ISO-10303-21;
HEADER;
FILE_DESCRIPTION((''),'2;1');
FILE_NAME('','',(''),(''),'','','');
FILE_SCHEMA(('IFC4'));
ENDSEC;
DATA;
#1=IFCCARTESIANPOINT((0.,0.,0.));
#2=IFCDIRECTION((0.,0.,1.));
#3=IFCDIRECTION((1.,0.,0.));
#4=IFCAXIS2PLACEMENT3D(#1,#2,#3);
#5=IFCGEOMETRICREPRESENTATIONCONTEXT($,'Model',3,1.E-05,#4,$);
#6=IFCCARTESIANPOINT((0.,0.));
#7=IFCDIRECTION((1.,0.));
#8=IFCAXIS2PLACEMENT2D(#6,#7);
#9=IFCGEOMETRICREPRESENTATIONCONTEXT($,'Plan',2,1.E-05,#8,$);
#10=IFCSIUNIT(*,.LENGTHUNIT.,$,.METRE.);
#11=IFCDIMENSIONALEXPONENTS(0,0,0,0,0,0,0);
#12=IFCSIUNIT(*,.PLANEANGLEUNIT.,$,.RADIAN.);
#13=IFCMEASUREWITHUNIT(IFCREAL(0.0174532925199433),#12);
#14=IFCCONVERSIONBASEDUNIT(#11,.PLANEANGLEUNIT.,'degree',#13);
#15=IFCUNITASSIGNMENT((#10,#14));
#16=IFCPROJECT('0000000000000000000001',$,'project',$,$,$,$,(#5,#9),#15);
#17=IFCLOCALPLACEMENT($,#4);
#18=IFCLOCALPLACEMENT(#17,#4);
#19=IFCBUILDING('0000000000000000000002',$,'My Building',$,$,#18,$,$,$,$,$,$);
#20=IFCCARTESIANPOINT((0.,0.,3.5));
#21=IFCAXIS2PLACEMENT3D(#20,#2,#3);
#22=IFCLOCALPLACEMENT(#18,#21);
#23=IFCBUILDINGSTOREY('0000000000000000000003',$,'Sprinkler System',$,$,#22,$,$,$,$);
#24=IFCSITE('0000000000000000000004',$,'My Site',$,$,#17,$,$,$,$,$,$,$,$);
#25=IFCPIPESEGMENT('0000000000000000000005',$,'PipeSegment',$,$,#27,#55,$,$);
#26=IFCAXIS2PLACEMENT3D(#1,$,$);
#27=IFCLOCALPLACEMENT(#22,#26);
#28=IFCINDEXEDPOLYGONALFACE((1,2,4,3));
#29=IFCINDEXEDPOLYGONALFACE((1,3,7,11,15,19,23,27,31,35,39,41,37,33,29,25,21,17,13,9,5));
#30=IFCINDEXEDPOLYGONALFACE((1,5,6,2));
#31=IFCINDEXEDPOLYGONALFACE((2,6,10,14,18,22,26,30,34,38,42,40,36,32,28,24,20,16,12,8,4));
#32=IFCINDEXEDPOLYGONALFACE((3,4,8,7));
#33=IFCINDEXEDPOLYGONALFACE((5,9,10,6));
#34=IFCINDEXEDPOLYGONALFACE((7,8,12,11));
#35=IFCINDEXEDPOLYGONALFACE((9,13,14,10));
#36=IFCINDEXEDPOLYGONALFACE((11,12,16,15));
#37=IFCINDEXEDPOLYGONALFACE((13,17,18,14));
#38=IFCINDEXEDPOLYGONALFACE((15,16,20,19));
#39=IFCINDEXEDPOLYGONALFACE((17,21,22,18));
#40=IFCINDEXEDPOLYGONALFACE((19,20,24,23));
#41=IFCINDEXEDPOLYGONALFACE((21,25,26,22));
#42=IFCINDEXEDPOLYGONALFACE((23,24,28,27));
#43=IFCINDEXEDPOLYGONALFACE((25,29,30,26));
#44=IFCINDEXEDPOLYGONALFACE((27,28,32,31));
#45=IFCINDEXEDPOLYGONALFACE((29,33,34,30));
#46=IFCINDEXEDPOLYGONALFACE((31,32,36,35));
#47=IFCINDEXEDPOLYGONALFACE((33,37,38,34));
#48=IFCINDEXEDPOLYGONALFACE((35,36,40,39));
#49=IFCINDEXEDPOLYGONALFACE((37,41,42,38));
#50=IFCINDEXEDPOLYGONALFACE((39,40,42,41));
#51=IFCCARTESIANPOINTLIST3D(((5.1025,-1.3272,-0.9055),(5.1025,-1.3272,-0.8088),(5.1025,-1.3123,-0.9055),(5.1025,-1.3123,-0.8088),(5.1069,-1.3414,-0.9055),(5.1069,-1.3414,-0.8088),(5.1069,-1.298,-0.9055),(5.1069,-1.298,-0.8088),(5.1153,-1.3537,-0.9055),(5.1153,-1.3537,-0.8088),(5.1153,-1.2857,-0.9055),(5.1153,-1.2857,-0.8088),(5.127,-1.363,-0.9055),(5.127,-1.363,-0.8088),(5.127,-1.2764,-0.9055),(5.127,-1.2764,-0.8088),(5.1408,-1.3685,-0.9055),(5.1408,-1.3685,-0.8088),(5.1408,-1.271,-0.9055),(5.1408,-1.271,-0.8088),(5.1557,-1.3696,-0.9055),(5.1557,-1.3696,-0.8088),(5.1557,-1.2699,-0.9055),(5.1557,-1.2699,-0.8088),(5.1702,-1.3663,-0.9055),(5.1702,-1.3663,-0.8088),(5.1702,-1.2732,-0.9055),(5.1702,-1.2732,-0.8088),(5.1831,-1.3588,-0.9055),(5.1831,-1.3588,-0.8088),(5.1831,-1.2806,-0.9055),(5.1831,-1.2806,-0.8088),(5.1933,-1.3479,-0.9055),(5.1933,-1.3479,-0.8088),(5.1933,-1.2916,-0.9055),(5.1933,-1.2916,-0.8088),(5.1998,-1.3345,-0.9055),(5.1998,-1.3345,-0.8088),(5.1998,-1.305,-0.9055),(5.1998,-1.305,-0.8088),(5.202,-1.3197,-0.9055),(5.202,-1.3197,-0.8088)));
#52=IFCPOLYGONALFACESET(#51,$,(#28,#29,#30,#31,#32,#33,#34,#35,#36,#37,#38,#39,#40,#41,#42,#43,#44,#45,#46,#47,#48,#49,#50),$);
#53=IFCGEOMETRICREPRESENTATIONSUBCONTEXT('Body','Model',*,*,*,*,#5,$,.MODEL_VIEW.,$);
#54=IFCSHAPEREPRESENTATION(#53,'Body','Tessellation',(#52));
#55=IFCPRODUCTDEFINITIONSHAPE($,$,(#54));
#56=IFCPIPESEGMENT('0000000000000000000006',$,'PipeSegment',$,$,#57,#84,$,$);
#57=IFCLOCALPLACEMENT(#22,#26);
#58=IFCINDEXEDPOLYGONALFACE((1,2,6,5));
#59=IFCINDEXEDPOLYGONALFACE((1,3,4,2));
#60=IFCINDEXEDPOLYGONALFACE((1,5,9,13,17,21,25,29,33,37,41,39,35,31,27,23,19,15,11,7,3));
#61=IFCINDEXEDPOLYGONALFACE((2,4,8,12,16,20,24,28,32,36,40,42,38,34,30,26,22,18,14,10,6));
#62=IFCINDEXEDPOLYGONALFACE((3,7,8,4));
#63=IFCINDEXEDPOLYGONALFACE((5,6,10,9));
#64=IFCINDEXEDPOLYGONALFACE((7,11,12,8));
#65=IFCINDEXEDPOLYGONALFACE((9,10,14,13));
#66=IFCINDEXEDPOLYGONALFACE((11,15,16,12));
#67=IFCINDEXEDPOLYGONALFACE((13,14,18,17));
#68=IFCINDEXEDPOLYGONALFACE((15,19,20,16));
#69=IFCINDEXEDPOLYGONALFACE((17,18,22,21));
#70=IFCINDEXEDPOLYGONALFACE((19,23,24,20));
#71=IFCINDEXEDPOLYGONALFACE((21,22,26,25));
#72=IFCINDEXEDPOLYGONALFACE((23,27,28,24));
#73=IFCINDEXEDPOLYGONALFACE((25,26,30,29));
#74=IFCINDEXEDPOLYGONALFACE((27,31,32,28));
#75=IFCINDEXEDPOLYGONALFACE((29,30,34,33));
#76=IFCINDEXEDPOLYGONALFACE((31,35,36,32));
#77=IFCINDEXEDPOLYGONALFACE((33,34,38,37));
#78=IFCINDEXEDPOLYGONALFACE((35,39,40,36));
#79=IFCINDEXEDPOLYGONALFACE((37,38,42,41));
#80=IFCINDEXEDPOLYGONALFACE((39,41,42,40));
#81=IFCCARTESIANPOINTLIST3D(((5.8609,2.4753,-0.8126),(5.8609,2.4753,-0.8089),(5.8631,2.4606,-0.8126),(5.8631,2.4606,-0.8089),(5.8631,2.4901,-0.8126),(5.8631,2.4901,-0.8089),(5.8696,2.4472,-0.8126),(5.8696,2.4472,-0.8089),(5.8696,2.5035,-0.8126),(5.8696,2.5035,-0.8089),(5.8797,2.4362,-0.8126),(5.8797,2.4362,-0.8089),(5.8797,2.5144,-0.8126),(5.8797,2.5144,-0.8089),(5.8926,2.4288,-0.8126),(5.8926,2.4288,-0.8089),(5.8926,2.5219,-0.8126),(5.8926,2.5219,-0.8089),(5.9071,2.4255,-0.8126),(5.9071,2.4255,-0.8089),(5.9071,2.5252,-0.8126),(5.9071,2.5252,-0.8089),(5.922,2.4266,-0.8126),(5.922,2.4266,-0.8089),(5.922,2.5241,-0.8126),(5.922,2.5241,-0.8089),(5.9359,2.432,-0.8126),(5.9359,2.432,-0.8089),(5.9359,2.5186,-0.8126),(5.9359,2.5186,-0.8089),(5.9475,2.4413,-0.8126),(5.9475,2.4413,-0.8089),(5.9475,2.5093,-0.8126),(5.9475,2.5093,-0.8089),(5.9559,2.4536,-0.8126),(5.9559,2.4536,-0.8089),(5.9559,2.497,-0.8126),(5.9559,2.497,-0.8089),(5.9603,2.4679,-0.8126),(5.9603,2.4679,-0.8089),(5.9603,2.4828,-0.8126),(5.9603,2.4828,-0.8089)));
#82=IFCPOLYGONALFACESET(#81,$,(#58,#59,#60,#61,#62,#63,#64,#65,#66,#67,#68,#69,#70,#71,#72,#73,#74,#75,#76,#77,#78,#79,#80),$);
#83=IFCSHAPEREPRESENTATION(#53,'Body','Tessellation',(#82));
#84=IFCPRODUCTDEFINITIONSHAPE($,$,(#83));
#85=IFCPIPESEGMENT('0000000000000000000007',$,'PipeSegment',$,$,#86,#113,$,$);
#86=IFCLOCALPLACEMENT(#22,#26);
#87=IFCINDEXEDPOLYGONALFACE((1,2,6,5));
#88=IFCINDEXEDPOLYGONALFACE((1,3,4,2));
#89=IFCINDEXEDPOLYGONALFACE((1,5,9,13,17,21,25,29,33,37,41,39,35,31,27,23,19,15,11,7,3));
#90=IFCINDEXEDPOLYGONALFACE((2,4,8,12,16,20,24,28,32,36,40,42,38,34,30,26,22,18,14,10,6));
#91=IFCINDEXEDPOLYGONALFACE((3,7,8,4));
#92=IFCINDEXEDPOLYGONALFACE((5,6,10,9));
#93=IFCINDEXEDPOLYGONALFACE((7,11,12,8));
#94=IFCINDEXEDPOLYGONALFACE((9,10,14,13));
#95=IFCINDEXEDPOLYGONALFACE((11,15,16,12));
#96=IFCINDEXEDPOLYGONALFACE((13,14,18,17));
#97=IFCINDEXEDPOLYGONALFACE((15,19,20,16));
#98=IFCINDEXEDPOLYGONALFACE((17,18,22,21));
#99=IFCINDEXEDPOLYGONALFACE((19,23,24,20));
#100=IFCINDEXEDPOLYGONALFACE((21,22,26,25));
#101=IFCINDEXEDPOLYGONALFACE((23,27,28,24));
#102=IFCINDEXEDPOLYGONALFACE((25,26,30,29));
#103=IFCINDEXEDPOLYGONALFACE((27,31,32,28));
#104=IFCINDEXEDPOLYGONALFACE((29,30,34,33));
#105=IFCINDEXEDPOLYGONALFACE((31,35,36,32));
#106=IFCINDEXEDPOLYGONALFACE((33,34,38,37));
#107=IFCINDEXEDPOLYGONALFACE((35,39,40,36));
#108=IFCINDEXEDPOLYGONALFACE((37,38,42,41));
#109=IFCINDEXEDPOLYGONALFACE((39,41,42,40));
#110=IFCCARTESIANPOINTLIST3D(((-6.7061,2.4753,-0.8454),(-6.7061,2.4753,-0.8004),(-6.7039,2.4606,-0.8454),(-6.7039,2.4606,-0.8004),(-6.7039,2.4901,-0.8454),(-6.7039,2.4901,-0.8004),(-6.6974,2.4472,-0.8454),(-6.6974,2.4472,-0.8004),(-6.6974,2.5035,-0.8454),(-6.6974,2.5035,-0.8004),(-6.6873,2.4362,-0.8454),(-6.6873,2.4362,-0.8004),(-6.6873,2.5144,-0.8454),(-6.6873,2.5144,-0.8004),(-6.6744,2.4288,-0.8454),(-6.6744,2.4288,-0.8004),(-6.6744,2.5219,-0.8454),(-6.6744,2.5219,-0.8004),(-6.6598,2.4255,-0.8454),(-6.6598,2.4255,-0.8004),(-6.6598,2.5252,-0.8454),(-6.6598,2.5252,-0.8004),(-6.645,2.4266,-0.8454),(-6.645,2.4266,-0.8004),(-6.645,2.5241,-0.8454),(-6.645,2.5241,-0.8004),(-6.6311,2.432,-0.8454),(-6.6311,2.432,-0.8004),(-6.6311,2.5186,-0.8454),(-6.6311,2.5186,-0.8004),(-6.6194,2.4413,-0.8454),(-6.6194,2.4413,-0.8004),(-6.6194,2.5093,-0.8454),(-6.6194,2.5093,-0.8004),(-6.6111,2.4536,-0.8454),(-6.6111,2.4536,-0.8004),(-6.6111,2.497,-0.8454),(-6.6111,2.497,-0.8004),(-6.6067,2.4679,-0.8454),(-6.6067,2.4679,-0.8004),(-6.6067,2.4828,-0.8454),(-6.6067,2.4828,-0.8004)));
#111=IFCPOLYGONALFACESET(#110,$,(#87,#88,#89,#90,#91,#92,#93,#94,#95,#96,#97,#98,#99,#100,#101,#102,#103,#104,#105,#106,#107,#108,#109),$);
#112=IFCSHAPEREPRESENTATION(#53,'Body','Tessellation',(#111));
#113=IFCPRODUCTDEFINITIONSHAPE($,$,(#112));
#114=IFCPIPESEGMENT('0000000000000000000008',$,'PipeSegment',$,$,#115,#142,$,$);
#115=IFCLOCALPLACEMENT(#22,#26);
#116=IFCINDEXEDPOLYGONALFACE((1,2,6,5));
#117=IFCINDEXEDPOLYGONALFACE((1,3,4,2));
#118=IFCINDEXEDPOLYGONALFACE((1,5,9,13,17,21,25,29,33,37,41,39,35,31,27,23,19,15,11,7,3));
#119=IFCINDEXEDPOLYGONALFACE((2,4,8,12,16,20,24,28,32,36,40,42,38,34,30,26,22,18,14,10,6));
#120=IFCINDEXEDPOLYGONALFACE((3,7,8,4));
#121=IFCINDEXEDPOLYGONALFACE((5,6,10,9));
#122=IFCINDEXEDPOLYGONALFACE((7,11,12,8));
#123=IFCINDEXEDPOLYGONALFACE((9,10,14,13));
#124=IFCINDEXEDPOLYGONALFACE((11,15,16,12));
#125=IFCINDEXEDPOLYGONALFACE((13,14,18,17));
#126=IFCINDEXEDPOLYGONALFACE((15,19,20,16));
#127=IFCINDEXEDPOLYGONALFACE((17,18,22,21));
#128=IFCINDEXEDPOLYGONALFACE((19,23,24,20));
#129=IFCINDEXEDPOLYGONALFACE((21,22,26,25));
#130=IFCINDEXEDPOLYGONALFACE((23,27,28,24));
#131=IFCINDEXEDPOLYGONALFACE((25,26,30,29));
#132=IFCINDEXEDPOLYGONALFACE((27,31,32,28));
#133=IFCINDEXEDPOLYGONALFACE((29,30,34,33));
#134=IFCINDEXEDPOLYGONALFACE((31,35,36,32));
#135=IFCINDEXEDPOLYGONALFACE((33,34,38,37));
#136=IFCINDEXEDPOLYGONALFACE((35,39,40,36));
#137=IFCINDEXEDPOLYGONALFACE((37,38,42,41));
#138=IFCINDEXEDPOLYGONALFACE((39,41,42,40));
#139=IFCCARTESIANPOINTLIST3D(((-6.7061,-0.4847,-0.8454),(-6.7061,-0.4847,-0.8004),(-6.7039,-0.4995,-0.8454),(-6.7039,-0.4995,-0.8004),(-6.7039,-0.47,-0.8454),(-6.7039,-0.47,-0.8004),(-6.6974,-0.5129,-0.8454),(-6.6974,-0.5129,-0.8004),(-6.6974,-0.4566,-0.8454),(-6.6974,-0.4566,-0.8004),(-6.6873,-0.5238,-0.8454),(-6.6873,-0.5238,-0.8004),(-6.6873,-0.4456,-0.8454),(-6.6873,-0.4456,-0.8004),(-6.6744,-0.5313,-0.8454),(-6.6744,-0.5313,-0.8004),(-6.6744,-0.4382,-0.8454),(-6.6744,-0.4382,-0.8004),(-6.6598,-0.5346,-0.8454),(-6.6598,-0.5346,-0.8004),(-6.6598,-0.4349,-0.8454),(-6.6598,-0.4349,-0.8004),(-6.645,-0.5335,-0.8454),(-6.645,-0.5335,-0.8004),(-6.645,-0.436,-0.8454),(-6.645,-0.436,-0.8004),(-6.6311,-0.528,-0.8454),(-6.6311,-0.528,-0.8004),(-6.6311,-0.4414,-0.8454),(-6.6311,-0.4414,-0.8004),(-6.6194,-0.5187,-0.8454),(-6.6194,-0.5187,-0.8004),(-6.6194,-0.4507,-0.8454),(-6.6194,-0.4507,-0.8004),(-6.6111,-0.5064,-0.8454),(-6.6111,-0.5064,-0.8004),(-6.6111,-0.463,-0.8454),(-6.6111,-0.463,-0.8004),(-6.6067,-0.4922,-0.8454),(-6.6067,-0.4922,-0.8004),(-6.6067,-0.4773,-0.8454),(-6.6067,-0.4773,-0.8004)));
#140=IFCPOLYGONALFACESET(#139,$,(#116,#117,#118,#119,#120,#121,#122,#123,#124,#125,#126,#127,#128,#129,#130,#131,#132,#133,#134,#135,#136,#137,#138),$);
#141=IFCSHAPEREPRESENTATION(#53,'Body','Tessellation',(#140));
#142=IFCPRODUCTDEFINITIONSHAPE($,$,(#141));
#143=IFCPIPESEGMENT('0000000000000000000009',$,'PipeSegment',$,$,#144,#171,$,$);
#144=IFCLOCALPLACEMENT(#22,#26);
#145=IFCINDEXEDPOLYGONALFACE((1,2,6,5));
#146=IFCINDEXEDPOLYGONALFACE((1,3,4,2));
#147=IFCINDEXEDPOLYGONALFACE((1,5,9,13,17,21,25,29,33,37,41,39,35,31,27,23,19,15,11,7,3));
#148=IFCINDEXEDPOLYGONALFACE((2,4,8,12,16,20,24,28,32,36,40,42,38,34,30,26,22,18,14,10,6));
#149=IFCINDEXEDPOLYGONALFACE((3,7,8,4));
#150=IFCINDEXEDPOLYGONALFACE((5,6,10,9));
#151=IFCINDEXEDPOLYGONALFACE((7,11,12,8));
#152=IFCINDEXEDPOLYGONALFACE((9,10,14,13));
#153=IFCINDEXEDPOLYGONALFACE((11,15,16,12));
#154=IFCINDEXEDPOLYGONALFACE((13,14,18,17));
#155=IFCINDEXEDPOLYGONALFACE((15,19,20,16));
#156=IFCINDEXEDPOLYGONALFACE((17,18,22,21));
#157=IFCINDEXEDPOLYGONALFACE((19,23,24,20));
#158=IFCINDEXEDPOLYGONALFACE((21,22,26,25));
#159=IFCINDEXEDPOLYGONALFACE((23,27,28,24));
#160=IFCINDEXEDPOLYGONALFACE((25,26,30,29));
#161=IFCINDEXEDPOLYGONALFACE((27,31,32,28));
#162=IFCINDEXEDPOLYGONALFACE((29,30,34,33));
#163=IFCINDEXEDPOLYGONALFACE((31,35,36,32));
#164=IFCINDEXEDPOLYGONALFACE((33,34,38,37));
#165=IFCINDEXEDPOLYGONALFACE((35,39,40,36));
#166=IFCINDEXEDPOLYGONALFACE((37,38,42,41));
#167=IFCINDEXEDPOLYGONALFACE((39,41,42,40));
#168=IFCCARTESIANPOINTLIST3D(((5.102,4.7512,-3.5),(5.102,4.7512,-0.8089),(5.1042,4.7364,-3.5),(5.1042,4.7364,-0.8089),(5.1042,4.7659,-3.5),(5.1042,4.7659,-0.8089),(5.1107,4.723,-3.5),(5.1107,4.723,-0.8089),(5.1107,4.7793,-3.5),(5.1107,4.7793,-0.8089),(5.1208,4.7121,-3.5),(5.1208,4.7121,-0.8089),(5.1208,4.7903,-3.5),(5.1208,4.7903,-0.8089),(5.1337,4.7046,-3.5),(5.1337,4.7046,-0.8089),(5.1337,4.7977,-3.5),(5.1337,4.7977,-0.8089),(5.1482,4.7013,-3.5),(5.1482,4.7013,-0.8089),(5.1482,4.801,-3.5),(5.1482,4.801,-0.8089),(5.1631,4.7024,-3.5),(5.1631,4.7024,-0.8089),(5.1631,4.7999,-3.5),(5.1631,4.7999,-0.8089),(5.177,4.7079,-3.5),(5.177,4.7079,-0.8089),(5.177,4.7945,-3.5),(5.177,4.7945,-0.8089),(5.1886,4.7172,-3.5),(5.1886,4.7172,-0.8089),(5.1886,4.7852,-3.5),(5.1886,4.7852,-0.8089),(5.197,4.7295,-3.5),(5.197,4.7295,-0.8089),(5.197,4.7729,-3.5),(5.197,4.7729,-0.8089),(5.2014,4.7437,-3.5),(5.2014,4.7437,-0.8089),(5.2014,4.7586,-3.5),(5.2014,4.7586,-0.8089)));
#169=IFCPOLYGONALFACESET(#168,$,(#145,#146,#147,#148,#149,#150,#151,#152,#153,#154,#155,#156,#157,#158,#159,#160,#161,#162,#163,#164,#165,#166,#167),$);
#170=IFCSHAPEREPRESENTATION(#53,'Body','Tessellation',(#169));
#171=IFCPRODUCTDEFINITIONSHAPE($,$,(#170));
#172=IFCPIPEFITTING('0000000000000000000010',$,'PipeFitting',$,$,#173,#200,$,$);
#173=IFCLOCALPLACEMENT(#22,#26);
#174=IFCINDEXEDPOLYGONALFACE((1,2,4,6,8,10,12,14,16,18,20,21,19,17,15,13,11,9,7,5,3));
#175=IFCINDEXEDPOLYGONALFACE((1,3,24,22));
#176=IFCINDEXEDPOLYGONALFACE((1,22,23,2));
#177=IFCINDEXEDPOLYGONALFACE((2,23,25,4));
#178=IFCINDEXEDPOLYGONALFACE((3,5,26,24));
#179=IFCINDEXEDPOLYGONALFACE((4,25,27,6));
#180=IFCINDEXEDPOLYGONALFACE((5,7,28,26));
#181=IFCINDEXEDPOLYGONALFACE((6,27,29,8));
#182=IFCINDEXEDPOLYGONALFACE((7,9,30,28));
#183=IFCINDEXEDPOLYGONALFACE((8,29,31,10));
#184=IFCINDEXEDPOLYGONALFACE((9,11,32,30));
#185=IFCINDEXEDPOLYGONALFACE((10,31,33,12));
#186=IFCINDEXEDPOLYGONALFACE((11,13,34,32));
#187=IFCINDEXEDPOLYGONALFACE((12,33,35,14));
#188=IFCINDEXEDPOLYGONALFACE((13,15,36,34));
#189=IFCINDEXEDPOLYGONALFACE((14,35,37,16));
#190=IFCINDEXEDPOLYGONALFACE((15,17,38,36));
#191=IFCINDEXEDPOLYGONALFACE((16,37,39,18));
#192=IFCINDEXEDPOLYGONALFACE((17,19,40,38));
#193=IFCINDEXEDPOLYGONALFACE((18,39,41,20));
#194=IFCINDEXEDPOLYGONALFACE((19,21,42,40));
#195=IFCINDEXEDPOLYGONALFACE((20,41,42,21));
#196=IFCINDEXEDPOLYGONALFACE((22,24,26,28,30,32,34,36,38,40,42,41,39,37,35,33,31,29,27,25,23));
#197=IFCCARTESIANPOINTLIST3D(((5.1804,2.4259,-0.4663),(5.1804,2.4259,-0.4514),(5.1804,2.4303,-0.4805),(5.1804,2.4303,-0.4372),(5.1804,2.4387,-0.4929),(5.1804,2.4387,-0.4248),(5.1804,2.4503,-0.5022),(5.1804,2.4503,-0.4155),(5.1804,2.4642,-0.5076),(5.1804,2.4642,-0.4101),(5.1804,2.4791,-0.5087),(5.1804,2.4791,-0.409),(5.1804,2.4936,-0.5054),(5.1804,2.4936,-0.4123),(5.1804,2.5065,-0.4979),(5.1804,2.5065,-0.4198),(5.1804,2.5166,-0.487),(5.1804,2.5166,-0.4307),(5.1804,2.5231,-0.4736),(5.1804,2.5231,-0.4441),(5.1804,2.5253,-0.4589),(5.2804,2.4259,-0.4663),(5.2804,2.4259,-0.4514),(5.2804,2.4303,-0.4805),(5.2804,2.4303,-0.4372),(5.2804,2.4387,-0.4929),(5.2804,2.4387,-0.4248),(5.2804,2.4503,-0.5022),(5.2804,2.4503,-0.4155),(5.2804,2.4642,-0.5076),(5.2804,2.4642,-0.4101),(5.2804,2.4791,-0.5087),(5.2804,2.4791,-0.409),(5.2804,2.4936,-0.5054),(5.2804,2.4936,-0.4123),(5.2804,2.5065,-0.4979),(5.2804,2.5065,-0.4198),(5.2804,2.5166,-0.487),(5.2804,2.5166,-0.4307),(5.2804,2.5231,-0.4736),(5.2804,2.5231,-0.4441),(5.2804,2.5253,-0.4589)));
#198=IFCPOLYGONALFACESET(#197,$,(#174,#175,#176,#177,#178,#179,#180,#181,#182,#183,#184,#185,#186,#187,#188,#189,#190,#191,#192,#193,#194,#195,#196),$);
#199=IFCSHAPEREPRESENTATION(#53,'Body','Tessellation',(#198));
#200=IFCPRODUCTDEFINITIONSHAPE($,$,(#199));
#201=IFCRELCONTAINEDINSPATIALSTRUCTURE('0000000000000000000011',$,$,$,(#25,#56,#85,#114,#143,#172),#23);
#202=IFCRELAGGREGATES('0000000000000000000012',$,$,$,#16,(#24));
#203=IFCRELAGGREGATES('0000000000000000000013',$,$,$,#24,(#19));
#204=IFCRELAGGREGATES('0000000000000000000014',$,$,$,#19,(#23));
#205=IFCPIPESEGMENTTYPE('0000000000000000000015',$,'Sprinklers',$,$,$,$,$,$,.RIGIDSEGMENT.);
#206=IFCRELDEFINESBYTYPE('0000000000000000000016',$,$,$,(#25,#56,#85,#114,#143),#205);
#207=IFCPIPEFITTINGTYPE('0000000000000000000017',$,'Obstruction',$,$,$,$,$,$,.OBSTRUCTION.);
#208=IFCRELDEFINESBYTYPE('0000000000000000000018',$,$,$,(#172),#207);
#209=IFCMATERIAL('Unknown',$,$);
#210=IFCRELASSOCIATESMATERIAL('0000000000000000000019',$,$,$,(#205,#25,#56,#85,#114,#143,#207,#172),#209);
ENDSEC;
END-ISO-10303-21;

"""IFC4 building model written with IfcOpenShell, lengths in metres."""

from ifc_helpers import new_model, entity, si_unit, converted_unit, frame, origin_with_axes, origin_2d_with_axis, place, context, subcontext, project, spatial, circle, extrude, material, material_profile, profile_set, profile_usage, type_object, element, save


model = new_model("IFC4")

# Units and contexts
model_context = context("Model", 3, precision=1e-05, world=origin_with_axes())
plan_context = context("Plan", 2, precision=1e-05, world=origin_2d_with_axis())
body_context = subcontext(model_context, "Body", "Model", "MODEL_VIEW")
ifc_project = project(units=[si_unit("LENGTHUNIT", "METRE"), converted_unit("PLANEANGLEUNIT", "degree", entity("IfcReal", 0.0174532925199433), si_unit("PLANEANGLEUNIT", "RADIAN"), dimensions=[0, 0, 0, 0, 0, 0, 0])], contexts=[model_context, plan_context])

# Site, building, storey
site_placement = place(None, origin_with_axes())
site = spatial("IfcSite", under=ifc_project, at=site_placement, Name="My Site")
building_placement = place(site_placement, origin_with_axes())
building = spatial("IfcBuilding", under=site, at=building_placement, Name="My Building")
storey_placement = place(building_placement, frame((0.0, 0.0, 3.5), z_axis=(0.0, 0.0, 1.0), x_axis=(1.0, 0.0, 0.0)))
storey = spatial("IfcBuildingStorey", under=building, at=storey_placement, Name="Sprinkler System")

# Pipe segments
ifc_material = material(Name="Unknown")
ifc_material_profile_1 = material_profile(ifc_material, circle(Radius=0.05))
ifc_profile_set_1 = profile_set([ifc_material_profile_1])
pipe_segment_type = type_object("IfcPipeSegmentType", Name="Sprinklers", PredefinedType="RIGIDSEGMENT", material=ifc_profile_set_1)
ifc_profile_usage_1 = profile_usage(ifc_profile_set_1, cardinal=5)
pipe_segment_1_placement = place(storey_placement, frame((5.152, -1.3197, -0.8088), z_axis=(0.0, -0.000034, -1.0), x_axis=(1.0, -0.000001, 0.0)))
element("IfcPipeSegment", 1, at=pipe_segment_1_placement, inside=storey, type_object=pipe_segment_type, material=ifc_profile_usage_1, Name="PipeSegment", context=body_context, shape_type="SweptSolid", body=[
    extrude(circle(Radius=0.05), origin_with_axes(), (0.0, 0.0, 1.0), 0.0967),
])
ifc_profile_usage_2 = profile_usage(ifc_profile_set_1, cardinal=5)
pipe_segment_2_placement = place(storey_placement, frame((5.9109, 2.4753, -0.8089), z_axis=(0.0, 0.0, -1.0), x_axis=(-1.0, 0.0, 0.0)))
element("IfcPipeSegment", 2, at=pipe_segment_2_placement, inside=storey, type_object=pipe_segment_type, material=ifc_profile_usage_2, Name="PipeSegment", context=body_context, shape_type="SweptSolid", body=[
    extrude(circle(Radius=0.05), origin_with_axes(), (0.0, 0.0, 1.0), 0.0038),
])
ifc_profile_usage_3 = profile_usage(ifc_profile_set_1, cardinal=5)
pipe_segment_3_placement = place(storey_placement, frame((-6.6561, 2.4753, -0.8004), z_axis=(0.0, 0.0, -1.0), x_axis=(-1.0, 0.0, 0.0)))
element("IfcPipeSegment", 3, at=pipe_segment_3_placement, inside=storey, type_object=pipe_segment_type, material=ifc_profile_usage_3, Name="PipeSegment", context=body_context, shape_type="SweptSolid", body=[
    extrude(circle(Radius=0.05), origin_with_axes(), (0.0, 0.0, 1.0), 0.0451),
])
ifc_profile_usage_4 = profile_usage(ifc_profile_set_1, cardinal=5)
pipe_segment_4_placement = place(storey_placement, frame((-6.6561, -0.4847, -0.8004), z_axis=(0.0, 0.0, -1.0), x_axis=(-1.0, 0.0, 0.0)))
element("IfcPipeSegment", 4, at=pipe_segment_4_placement, inside=storey, type_object=pipe_segment_type, material=ifc_profile_usage_4, Name="PipeSegment", context=body_context, shape_type="SweptSolid", body=[
    extrude(circle(Radius=0.05), origin_with_axes(), (0.0, 0.0, 1.0), 0.0451),
])
ifc_profile_usage_5 = profile_usage(ifc_profile_set_1, cardinal=5)
pipe_segment_5_placement = place(storey_placement, frame((5.152, 4.7512, -0.8089), z_axis=(0.0, 0.0, -1.0), x_axis=(-1.0, 0.0, 0.0)))
element("IfcPipeSegment", 5, at=pipe_segment_5_placement, inside=storey, type_object=pipe_segment_type, material=ifc_profile_usage_5, Name="PipeSegment", context=body_context, shape_type="SweptSolid", body=[
    extrude(circle(Radius=0.05), origin_with_axes(), (0.0, 0.0, 1.0), 2.6911),
])

# Pipe fitting
ifc_material_profile_2 = material_profile(ifc_material, circle(Radius=0.05))
ifc_profile_set_2 = profile_set([ifc_material_profile_2])
ifc_profile_usage_6 = profile_usage(ifc_profile_set_2, cardinal=5)
pipe_fitting_type_1 = type_object("IfcPipeFittingType", Name="Obstruction", PredefinedType="OBSTRUCTION", material=ifc_profile_set_2)
pipe_fitting_1_placement = place(storey_placement, frame((5.1804, 2.4753, -0.4589), z_axis=(1.0, 0.0, 0.0), x_axis=(0.0, 1.0, 0.0)))
element("IfcPipeFitting", 6, at=pipe_fitting_1_placement, inside=storey, type_object=pipe_fitting_type_1, material=ifc_profile_usage_6, Name="PipeFitting", context=body_context, shape_type="SweptSolid", body=[
    extrude(circle(Radius=0.05), origin_with_axes(), (0.0, 0.0, 1.0), 0.1),
])

save(model, "model.ifc")
